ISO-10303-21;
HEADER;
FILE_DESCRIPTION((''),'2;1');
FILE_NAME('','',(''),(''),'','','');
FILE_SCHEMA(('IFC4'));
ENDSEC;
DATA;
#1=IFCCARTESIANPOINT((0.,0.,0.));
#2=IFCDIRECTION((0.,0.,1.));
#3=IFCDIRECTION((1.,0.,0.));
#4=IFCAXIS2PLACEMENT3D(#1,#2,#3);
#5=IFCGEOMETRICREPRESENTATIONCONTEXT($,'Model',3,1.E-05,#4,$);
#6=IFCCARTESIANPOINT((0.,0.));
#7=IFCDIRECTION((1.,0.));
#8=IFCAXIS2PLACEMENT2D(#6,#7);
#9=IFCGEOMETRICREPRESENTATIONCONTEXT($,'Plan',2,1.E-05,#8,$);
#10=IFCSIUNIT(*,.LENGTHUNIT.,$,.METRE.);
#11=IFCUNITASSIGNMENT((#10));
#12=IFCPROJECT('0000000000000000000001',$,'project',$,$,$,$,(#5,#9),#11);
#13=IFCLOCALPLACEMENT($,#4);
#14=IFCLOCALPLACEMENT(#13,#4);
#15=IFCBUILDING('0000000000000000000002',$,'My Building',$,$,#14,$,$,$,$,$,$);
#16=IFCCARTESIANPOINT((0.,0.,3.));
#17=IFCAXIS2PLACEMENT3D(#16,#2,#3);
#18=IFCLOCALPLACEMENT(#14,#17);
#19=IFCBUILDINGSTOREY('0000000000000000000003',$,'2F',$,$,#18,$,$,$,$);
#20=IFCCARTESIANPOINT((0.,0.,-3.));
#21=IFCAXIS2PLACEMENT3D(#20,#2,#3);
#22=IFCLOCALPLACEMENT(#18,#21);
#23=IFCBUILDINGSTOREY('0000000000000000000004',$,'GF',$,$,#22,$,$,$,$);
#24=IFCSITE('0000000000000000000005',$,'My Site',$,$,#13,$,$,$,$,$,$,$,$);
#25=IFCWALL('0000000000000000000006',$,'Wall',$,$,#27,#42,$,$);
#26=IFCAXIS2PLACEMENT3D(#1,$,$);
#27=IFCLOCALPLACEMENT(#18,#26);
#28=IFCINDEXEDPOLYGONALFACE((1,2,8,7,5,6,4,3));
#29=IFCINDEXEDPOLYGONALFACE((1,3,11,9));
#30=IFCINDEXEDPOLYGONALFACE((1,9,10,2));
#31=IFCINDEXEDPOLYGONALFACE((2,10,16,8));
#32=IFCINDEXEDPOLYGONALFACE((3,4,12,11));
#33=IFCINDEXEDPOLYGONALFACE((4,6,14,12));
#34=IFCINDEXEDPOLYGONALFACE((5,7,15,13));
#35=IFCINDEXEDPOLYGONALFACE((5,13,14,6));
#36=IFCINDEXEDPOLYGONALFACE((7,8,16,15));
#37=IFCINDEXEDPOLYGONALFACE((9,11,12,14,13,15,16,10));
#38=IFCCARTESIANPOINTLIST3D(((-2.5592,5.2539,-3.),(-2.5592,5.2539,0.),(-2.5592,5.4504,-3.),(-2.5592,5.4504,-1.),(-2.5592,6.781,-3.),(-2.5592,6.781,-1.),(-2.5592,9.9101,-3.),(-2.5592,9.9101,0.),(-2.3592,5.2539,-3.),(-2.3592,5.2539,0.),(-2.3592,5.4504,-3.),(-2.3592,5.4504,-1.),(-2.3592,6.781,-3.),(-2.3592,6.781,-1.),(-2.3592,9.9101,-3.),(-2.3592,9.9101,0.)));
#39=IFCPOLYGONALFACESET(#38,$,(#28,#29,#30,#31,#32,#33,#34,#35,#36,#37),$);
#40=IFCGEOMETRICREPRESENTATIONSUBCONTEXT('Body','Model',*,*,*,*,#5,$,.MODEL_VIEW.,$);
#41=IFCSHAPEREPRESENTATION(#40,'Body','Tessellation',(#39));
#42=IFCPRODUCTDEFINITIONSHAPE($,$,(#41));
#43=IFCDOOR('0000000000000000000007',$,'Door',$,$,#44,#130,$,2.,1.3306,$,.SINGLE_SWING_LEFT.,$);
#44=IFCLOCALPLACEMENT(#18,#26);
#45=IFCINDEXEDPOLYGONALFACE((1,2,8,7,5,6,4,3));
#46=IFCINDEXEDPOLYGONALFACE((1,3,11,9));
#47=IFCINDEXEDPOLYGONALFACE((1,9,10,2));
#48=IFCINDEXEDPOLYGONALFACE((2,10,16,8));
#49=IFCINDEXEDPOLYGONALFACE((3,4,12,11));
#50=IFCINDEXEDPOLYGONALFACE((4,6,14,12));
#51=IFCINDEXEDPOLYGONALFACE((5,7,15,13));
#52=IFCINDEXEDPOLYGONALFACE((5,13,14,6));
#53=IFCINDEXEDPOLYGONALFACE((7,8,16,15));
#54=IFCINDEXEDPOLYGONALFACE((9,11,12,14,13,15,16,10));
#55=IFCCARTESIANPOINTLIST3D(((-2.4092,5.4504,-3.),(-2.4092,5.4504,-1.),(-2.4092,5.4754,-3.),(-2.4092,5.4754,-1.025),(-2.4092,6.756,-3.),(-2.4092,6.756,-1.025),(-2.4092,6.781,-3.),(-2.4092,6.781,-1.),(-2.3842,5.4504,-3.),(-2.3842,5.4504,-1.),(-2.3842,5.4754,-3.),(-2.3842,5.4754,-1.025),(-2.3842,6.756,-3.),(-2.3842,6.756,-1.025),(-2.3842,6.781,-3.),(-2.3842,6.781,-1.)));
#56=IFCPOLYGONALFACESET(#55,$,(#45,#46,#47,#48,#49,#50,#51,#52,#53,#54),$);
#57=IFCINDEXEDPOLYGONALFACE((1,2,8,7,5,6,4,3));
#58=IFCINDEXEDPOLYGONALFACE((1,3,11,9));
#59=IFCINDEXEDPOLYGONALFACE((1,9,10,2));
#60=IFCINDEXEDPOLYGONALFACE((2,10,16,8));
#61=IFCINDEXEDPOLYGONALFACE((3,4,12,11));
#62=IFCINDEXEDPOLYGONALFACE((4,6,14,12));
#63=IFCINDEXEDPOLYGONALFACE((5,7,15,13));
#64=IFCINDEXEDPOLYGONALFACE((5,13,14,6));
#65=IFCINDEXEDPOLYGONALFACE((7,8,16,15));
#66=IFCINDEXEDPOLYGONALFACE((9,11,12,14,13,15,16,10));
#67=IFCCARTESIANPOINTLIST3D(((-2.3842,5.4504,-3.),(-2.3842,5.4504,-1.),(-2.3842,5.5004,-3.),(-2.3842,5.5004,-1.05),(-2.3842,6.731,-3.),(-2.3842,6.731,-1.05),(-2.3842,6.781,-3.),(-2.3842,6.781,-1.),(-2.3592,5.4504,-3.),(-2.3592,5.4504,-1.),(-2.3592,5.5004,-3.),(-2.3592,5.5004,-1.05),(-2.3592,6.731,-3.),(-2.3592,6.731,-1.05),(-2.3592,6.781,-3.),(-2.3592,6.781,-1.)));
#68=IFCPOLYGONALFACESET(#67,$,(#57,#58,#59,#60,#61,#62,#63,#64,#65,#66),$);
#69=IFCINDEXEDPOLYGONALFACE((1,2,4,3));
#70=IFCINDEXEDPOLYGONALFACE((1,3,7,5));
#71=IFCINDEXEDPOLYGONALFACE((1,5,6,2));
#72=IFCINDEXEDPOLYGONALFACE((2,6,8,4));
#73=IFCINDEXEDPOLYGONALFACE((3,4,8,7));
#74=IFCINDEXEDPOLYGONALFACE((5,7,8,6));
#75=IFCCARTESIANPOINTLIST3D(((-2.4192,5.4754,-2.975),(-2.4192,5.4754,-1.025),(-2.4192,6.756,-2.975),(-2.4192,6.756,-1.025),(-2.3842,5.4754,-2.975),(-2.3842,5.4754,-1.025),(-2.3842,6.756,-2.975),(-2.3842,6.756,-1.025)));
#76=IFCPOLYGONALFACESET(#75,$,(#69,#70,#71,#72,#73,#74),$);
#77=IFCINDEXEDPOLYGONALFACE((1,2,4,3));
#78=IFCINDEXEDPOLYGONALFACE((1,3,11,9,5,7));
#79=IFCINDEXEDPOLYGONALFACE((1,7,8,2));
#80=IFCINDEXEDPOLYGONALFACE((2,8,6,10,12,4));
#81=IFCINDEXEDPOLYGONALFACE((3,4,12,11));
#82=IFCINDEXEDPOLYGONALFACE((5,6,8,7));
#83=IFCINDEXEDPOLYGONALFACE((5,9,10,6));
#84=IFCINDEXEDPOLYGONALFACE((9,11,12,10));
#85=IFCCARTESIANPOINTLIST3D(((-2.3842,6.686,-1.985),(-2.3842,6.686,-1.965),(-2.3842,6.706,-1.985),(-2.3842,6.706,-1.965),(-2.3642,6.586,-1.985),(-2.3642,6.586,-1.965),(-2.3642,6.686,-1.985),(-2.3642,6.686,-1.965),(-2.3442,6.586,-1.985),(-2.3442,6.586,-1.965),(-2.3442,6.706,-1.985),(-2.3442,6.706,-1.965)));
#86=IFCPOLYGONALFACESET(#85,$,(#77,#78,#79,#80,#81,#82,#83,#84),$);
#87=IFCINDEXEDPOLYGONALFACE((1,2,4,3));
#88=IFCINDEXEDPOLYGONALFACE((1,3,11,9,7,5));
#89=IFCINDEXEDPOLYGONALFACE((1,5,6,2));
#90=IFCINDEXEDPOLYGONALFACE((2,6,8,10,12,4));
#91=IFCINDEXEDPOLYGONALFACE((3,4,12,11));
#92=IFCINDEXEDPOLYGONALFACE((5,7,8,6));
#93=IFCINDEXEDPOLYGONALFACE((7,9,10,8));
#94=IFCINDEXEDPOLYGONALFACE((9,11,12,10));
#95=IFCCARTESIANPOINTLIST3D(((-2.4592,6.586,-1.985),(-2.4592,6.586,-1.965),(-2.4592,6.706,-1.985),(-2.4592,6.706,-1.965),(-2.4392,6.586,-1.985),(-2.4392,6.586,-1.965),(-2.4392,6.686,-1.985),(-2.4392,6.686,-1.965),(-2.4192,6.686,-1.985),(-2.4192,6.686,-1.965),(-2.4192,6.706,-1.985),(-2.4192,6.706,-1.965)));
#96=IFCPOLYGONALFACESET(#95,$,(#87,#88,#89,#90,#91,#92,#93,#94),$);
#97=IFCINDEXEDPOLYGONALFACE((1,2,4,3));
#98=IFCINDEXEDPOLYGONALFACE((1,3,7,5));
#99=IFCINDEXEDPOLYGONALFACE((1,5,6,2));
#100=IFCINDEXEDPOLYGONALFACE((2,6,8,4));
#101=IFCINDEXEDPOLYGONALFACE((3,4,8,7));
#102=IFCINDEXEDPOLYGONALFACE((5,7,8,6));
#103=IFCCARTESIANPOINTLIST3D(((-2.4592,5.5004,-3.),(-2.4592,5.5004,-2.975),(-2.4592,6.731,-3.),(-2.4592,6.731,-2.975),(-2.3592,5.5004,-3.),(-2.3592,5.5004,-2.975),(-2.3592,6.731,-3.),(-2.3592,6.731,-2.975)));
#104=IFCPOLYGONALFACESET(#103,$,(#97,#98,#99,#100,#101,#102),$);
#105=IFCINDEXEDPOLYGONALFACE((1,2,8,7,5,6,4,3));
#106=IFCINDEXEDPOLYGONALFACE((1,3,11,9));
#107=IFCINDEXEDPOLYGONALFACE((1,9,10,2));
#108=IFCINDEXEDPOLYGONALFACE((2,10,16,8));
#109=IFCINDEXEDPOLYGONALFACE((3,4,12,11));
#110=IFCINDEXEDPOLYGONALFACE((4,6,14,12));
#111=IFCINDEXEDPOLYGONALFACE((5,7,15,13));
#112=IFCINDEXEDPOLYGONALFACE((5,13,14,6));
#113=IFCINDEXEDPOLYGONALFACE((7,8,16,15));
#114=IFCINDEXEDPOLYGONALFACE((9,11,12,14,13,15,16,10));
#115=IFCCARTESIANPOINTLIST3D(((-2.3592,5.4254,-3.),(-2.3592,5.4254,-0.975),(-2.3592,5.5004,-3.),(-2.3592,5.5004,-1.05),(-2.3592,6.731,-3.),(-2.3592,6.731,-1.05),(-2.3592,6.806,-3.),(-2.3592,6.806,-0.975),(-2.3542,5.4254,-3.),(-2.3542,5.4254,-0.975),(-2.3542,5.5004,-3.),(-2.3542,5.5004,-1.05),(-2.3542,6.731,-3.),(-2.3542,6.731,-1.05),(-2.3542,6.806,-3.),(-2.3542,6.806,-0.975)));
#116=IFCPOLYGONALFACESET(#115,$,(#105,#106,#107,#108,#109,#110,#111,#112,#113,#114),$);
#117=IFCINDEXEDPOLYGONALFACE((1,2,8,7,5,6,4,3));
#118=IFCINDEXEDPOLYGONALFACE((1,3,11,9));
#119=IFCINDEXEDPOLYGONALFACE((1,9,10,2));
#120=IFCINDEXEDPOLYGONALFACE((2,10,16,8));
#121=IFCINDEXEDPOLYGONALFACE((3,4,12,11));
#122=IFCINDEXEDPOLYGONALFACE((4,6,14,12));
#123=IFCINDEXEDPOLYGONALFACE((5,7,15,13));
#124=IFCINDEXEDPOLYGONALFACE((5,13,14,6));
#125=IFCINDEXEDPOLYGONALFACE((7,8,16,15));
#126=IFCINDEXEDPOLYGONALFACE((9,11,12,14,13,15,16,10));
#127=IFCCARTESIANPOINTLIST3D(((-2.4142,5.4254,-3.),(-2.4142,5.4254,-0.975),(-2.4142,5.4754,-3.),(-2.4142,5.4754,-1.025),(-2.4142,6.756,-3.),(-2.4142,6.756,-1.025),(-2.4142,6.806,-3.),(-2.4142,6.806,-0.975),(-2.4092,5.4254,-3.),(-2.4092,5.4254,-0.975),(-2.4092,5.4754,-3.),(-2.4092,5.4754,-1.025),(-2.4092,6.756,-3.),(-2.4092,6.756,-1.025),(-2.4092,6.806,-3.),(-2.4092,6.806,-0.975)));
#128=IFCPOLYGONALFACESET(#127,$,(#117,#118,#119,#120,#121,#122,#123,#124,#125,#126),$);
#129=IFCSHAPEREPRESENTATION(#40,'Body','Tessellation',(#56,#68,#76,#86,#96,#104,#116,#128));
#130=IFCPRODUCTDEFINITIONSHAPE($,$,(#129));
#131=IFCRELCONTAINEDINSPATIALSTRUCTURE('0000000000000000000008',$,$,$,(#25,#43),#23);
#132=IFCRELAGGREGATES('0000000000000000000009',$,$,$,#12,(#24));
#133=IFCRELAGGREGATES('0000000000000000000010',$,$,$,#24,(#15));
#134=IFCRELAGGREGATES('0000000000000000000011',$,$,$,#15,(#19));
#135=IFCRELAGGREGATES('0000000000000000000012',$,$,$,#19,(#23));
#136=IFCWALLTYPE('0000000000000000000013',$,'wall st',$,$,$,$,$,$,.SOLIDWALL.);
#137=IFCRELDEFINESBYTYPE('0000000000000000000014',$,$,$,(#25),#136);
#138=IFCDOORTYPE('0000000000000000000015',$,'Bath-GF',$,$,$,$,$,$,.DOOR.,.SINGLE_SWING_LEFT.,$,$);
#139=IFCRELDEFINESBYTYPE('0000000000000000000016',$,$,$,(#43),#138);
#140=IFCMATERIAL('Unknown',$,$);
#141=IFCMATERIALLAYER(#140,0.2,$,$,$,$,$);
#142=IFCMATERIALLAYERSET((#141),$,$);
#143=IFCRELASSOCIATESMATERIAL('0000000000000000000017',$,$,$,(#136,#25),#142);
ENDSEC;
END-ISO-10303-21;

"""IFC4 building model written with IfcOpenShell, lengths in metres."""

from ifc_helpers import new_model, entity, si_unit, frame, origin_with_axes, origin_2d_with_axis, place, context, subcontext, project, spatial, line, indexed_curve, outline, extrude, shape, source, transform, mapped, material, layer, layer_set, layer_usage, type_object, type_shapes, element, fill, save


model = new_model("IFC4")

# Units and contexts
model_context = context("Model", 3, precision=1e-05, world=origin_with_axes())
plan_context = context("Plan", 2, precision=1e-05, world=origin_2d_with_axis())
body_context_1 = subcontext(model_context, "Body", "Model", "MODEL_VIEW")
body_context_2 = subcontext(plan_context, "Body", "Plan", "PLAN_VIEW")
ifc_project = project(units=[si_unit("LENGTHUNIT", "METRE")], contexts=[model_context, plan_context])

# Site, building, storeys
site_placement = place(None, origin_with_axes())
site = spatial("IfcSite", under=ifc_project, at=site_placement, Name="My Site")
building_placement = place(site_placement, origin_with_axes())
building = spatial("IfcBuilding", under=site, at=building_placement, Name="My Building")
storey_1_placement = place(building_placement, frame((0.0, 0.0, 3.0), z_axis=(0.0, 0.0, 1.0), x_axis=(1.0, 0.0, 0.0)))
storey_1 = spatial("IfcBuildingStorey", under=building, at=storey_1_placement, Name="2F")
storey_2_placement = place(storey_1_placement, frame((0.0, 0.0, -3.0), z_axis=(0.0, 0.0, 1.0), x_axis=(1.0, 0.0, 0.0)))
storey_2 = spatial("IfcBuildingStorey", under=storey_1, at=storey_2_placement, Name="GF")

# Shared definitions
ifc_material = material(Name="Unknown")

# Shared definitions
ifc_layer_1 = layer(ifc_material, 0.2)
ifc_layer_set_1 = layer_set([ifc_layer_1])
wall_type = type_object("IfcWallType", Name="wall st", PredefinedType="SOLIDWALL", material=ifc_layer_set_1)

# Wall, opening, door
ifc_layer_usage_1 = layer_usage(ifc_layer_set_1, "AXIS2", "POSITIVE", 0.0)
wall_1_placement = place(storey_2_placement, frame((-2.5592, 10.1101, 0.0), z_axis=(0.0, 0.0, 1.0), x_axis=(0.0, -1.0, 0.0)))
wall_1 = element("IfcWall", 1, at=wall_1_placement, inside=storey_2, type_object=wall_type, material=ifc_layer_usage_1, Name="Wall", context=body_context_1, shape_type="SweptSolid", body=[
    extrude(outline(indexed_curve([(0.2, 0.0), (0.2, 0.2), (4.8561, 0.2), (4.8561, 0.0)], segments=[line(1, 2, 3, 4, 1)])), origin_with_axes(), (0.0, 0.0, 1.0), 3.0),
])
shared_shape_1 = source(origin_with_axes(), body_context_1, "Body", "SweptSolid", [
    extrude(outline(indexed_curve([(0.0, 0.0), (1.3306, 0.0), (1.3306, 2.0), (0.0, 2.0)], segments=[line(1, 2, 3, 4, 1)])), frame((0.0, -0.6, 0.0), z_axis=(0.0, -1.0, 0.0), x_axis=(1.0, 0.0, 0.0)), (0.0, 0.0, -1.0), 1.2),
])
opening_1_placement = place(wall_1_placement, frame((4.6597, 0.2, 0.0), z_axis=(0.0, 0.0, 1.0), x_axis=(-1.0, 0.0, 0.0)))
opening_1 = element("IfcOpeningElement", 2, at=opening_1_placement, cuts=wall_1, PredefinedType="OPENING", context=body_context_1, shape_type="MappedRepresentation", body=[
    mapped(shared_shape_1, transform((0.0, 0.0, 0.0), x_axis=(1.0, 0.0, 0.0), y_axis=(0.0, 1.0, 0.0), z_axis=(0.0, 0.0, 1.0), scale=1.0)),
])
door_type_1 = type_object("IfcDoorType", Name="Bath-GF", OperationType="SINGLE_SWING_LEFT", PredefinedType="DOOR")
shared_shape_2 = source(origin_with_axes(), body_context_1, "Body", "SweptSolid", [
    extrude(outline(indexed_curve([(0.0, 0.0), (0.0, 2.0), (1.3306, 2.0), (1.3306, 0.0), (1.3056, 0.0), (1.3056, 1.975), (0.025, 1.975), (0.025, 0.0)], segments=[line(1, 2, 3, 4, 5, 6, 7, 8, 1)])), frame((0.0, 0.025, 0.0), z_axis=(0.0, -1.0, 0.0), x_axis=(1.0, 0.0, 0.0)), (0.0, 0.0, -1.0), 0.025),
    extrude(outline(indexed_curve([(0.0, 0.0), (0.0, 2.0), (1.3306, 2.0), (1.3306, 0.0), (1.2806, 0.0), (1.2806, 1.95), (0.05, 1.95), (0.05, 0.0)], segments=[line(1, 2, 3, 4, 5, 6, 7, 8, 1)])), frame((0.0, 0.0, 0.0), z_axis=(0.0, -1.0, 0.0), x_axis=(1.0, 0.0, 0.0)), (0.0, 0.0, -1.0), 0.025),
    extrude(outline(indexed_curve([(0.0, 0.0), (1.2806, 0.0), (1.2806, 0.035), (0.0, 0.035)], segments=[line(1, 2, 3, 4, 1)])), frame((0.025, 0.025, 0.025), z_axis=(0.0, 0.0, 1.0), x_axis=(1.0, 0.0, 0.0)), (0.0, 0.0, 1.0), 1.95),
    extrude(outline(indexed_curve([(0.0, 0.0), (0.0, -0.04), (-0.12, -0.04), (-0.12, -0.02), (-0.02, -0.02), (-0.02, 0.0)], segments=[line(1, 2, 3, 4, 5, 6, 1)])), frame((1.2556, 0.025, 1.015), z_axis=(0.0, 0.0, 1.0), x_axis=(1.0, 0.0, 0.0)), (0.0, 0.0, 1.0), 0.02),
    extrude(outline(indexed_curve([(0.0, 0.0), (0.0, 0.04), (-0.12, 0.04), (-0.12, 0.02), (-0.02, 0.02), (-0.02, 0.0)], segments=[line(1, 2, 3, 4, 5, 6, 1)])), frame((1.2556, 0.06, 1.015), z_axis=(0.0, 0.0, 1.0), x_axis=(1.0, 0.0, 0.0)), (0.0, 0.0, 1.0), 0.02),
    extrude(outline(indexed_curve([(0.0, 0.0), (1.2306, 0.0), (1.2306, 0.1), (0.0, 0.1)], segments=[line(1, 2, 3, 4, 1)])), frame((0.05, 0.0, 0.0), z_axis=(0.0, 0.0, 1.0), x_axis=(1.0, 0.0, 0.0)), (0.0, 0.0, 1.0), 0.025),
    extrude(outline(indexed_curve([(0.0, 0.0), (0.0, 2.025), (1.3806, 2.025), (1.3806, 0.0), (1.3056, 0.0), (1.3056, 1.95), (0.075, 1.95), (0.075, 0.0)], segments=[line(1, 2, 3, 4, 5, 6, 7, 8, 1)])), frame((-0.025, -0.005, 0.0), z_axis=(0.0, -1.0, 0.0), x_axis=(1.0, 0.0, 0.0)), (0.0, 0.0, -1.0), 0.005),
    extrude(outline(indexed_curve([(0.0, 0.0), (0.0, 2.025), (1.3806, 2.025), (1.3806, 0.0), (1.3306, 0.0), (1.3306, 1.975), (0.05, 1.975), (0.05, 0.0)], segments=[line(1, 2, 3, 4, 5, 6, 7, 8, 1)])), frame((-0.025, 0.05, 0.0), z_axis=(0.0, -1.0, 0.0), x_axis=(1.0, 0.0, 0.0)), (0.0, 0.0, -1.0), 0.005),
])
shared_shape_3 = source(origin_with_axes(), body_context_2, "Body", "Curve2D", [
    entity("IfcIndexedPolyCurve", entity("IfcCartesianPointList2D", [[0.0, 0.0], [0.0, 0.05], [0.025, 0.05], [0.025, 0.025], [0.05, 0.025], [0.05, 0.0]]), [entity("IfcLineIndex", [1, 2, 3, 4, 5, 6, 1])]),
    entity("IfcIndexedPolyCurve", entity("IfcCartesianPointList2D", [[1.3306, 0.0], [1.3306, 0.05], [1.3056, 0.05], [1.3056, 0.025], [1.2806, 0.025], [1.2806, 0.0]]), [entity("IfcLineIndex", [1, 2, 3, 4, 5, 6, 1])]),
    entity("IfcTrimmedCurve", entity("IfcEllipse", entity("IfcAxis2Placement2D", entity("IfcCartesianPoint", [0.06, 0.05]), entity("IfcDirection", [1.0, 0.0])), 1.2456, 1.2806), [entity("IfcCartesianPoint", [1.3056, 0.05])], [entity("IfcCartesianPoint", [0.06, 1.3306])], True, "CARTESIAN"),
    entity("IfcIndexedPolyCurve", entity("IfcCartesianPointList2D", [[0.025, 0.05], [0.06, 0.05], [0.06, 1.3306], [0.025, 1.3306]]), [entity("IfcLineIndex", [1, 2, 3, 4, 1])]),
])
type_shapes(door_type_1, [shared_shape_2, shared_shape_3])
door_1_placement = place(opening_1_placement, frame((0.0, 0.0, 0.0), z_axis=(0.0, 0.0, 1.0), x_axis=(1.0, 0.0, 0.0)))
door_1 = element("IfcDoor", 3, at=door_1_placement, inside=storey_2, type_object=door_type_1, Name="Door", OperationType="SINGLE_SWING_LEFT", OverallHeight=2.0, OverallWidth=1.3306, shapes=[
    shape(body_context_1, "Body", "MappedRepresentation", [mapped(shared_shape_2, transform((0.0, 0.0, 0.0), x_axis=(1.0, 0.0, 0.0), y_axis=(0.0, 1.0, 0.0), z_axis=(0.0, 0.0, 1.0), scale=1.0))]),
    shape(body_context_2, "Body", "MappedRepresentation", [mapped(shared_shape_3, transform((0.0, 0.0, 0.0), x_axis=(1.0, 0.0, 0.0), y_axis=(0.0, 1.0, 0.0), z_axis=(0.0, 0.0, 1.0), scale=1.0))]),
])
fill(opening_1, door_1)

save(model, "model.ifc")
